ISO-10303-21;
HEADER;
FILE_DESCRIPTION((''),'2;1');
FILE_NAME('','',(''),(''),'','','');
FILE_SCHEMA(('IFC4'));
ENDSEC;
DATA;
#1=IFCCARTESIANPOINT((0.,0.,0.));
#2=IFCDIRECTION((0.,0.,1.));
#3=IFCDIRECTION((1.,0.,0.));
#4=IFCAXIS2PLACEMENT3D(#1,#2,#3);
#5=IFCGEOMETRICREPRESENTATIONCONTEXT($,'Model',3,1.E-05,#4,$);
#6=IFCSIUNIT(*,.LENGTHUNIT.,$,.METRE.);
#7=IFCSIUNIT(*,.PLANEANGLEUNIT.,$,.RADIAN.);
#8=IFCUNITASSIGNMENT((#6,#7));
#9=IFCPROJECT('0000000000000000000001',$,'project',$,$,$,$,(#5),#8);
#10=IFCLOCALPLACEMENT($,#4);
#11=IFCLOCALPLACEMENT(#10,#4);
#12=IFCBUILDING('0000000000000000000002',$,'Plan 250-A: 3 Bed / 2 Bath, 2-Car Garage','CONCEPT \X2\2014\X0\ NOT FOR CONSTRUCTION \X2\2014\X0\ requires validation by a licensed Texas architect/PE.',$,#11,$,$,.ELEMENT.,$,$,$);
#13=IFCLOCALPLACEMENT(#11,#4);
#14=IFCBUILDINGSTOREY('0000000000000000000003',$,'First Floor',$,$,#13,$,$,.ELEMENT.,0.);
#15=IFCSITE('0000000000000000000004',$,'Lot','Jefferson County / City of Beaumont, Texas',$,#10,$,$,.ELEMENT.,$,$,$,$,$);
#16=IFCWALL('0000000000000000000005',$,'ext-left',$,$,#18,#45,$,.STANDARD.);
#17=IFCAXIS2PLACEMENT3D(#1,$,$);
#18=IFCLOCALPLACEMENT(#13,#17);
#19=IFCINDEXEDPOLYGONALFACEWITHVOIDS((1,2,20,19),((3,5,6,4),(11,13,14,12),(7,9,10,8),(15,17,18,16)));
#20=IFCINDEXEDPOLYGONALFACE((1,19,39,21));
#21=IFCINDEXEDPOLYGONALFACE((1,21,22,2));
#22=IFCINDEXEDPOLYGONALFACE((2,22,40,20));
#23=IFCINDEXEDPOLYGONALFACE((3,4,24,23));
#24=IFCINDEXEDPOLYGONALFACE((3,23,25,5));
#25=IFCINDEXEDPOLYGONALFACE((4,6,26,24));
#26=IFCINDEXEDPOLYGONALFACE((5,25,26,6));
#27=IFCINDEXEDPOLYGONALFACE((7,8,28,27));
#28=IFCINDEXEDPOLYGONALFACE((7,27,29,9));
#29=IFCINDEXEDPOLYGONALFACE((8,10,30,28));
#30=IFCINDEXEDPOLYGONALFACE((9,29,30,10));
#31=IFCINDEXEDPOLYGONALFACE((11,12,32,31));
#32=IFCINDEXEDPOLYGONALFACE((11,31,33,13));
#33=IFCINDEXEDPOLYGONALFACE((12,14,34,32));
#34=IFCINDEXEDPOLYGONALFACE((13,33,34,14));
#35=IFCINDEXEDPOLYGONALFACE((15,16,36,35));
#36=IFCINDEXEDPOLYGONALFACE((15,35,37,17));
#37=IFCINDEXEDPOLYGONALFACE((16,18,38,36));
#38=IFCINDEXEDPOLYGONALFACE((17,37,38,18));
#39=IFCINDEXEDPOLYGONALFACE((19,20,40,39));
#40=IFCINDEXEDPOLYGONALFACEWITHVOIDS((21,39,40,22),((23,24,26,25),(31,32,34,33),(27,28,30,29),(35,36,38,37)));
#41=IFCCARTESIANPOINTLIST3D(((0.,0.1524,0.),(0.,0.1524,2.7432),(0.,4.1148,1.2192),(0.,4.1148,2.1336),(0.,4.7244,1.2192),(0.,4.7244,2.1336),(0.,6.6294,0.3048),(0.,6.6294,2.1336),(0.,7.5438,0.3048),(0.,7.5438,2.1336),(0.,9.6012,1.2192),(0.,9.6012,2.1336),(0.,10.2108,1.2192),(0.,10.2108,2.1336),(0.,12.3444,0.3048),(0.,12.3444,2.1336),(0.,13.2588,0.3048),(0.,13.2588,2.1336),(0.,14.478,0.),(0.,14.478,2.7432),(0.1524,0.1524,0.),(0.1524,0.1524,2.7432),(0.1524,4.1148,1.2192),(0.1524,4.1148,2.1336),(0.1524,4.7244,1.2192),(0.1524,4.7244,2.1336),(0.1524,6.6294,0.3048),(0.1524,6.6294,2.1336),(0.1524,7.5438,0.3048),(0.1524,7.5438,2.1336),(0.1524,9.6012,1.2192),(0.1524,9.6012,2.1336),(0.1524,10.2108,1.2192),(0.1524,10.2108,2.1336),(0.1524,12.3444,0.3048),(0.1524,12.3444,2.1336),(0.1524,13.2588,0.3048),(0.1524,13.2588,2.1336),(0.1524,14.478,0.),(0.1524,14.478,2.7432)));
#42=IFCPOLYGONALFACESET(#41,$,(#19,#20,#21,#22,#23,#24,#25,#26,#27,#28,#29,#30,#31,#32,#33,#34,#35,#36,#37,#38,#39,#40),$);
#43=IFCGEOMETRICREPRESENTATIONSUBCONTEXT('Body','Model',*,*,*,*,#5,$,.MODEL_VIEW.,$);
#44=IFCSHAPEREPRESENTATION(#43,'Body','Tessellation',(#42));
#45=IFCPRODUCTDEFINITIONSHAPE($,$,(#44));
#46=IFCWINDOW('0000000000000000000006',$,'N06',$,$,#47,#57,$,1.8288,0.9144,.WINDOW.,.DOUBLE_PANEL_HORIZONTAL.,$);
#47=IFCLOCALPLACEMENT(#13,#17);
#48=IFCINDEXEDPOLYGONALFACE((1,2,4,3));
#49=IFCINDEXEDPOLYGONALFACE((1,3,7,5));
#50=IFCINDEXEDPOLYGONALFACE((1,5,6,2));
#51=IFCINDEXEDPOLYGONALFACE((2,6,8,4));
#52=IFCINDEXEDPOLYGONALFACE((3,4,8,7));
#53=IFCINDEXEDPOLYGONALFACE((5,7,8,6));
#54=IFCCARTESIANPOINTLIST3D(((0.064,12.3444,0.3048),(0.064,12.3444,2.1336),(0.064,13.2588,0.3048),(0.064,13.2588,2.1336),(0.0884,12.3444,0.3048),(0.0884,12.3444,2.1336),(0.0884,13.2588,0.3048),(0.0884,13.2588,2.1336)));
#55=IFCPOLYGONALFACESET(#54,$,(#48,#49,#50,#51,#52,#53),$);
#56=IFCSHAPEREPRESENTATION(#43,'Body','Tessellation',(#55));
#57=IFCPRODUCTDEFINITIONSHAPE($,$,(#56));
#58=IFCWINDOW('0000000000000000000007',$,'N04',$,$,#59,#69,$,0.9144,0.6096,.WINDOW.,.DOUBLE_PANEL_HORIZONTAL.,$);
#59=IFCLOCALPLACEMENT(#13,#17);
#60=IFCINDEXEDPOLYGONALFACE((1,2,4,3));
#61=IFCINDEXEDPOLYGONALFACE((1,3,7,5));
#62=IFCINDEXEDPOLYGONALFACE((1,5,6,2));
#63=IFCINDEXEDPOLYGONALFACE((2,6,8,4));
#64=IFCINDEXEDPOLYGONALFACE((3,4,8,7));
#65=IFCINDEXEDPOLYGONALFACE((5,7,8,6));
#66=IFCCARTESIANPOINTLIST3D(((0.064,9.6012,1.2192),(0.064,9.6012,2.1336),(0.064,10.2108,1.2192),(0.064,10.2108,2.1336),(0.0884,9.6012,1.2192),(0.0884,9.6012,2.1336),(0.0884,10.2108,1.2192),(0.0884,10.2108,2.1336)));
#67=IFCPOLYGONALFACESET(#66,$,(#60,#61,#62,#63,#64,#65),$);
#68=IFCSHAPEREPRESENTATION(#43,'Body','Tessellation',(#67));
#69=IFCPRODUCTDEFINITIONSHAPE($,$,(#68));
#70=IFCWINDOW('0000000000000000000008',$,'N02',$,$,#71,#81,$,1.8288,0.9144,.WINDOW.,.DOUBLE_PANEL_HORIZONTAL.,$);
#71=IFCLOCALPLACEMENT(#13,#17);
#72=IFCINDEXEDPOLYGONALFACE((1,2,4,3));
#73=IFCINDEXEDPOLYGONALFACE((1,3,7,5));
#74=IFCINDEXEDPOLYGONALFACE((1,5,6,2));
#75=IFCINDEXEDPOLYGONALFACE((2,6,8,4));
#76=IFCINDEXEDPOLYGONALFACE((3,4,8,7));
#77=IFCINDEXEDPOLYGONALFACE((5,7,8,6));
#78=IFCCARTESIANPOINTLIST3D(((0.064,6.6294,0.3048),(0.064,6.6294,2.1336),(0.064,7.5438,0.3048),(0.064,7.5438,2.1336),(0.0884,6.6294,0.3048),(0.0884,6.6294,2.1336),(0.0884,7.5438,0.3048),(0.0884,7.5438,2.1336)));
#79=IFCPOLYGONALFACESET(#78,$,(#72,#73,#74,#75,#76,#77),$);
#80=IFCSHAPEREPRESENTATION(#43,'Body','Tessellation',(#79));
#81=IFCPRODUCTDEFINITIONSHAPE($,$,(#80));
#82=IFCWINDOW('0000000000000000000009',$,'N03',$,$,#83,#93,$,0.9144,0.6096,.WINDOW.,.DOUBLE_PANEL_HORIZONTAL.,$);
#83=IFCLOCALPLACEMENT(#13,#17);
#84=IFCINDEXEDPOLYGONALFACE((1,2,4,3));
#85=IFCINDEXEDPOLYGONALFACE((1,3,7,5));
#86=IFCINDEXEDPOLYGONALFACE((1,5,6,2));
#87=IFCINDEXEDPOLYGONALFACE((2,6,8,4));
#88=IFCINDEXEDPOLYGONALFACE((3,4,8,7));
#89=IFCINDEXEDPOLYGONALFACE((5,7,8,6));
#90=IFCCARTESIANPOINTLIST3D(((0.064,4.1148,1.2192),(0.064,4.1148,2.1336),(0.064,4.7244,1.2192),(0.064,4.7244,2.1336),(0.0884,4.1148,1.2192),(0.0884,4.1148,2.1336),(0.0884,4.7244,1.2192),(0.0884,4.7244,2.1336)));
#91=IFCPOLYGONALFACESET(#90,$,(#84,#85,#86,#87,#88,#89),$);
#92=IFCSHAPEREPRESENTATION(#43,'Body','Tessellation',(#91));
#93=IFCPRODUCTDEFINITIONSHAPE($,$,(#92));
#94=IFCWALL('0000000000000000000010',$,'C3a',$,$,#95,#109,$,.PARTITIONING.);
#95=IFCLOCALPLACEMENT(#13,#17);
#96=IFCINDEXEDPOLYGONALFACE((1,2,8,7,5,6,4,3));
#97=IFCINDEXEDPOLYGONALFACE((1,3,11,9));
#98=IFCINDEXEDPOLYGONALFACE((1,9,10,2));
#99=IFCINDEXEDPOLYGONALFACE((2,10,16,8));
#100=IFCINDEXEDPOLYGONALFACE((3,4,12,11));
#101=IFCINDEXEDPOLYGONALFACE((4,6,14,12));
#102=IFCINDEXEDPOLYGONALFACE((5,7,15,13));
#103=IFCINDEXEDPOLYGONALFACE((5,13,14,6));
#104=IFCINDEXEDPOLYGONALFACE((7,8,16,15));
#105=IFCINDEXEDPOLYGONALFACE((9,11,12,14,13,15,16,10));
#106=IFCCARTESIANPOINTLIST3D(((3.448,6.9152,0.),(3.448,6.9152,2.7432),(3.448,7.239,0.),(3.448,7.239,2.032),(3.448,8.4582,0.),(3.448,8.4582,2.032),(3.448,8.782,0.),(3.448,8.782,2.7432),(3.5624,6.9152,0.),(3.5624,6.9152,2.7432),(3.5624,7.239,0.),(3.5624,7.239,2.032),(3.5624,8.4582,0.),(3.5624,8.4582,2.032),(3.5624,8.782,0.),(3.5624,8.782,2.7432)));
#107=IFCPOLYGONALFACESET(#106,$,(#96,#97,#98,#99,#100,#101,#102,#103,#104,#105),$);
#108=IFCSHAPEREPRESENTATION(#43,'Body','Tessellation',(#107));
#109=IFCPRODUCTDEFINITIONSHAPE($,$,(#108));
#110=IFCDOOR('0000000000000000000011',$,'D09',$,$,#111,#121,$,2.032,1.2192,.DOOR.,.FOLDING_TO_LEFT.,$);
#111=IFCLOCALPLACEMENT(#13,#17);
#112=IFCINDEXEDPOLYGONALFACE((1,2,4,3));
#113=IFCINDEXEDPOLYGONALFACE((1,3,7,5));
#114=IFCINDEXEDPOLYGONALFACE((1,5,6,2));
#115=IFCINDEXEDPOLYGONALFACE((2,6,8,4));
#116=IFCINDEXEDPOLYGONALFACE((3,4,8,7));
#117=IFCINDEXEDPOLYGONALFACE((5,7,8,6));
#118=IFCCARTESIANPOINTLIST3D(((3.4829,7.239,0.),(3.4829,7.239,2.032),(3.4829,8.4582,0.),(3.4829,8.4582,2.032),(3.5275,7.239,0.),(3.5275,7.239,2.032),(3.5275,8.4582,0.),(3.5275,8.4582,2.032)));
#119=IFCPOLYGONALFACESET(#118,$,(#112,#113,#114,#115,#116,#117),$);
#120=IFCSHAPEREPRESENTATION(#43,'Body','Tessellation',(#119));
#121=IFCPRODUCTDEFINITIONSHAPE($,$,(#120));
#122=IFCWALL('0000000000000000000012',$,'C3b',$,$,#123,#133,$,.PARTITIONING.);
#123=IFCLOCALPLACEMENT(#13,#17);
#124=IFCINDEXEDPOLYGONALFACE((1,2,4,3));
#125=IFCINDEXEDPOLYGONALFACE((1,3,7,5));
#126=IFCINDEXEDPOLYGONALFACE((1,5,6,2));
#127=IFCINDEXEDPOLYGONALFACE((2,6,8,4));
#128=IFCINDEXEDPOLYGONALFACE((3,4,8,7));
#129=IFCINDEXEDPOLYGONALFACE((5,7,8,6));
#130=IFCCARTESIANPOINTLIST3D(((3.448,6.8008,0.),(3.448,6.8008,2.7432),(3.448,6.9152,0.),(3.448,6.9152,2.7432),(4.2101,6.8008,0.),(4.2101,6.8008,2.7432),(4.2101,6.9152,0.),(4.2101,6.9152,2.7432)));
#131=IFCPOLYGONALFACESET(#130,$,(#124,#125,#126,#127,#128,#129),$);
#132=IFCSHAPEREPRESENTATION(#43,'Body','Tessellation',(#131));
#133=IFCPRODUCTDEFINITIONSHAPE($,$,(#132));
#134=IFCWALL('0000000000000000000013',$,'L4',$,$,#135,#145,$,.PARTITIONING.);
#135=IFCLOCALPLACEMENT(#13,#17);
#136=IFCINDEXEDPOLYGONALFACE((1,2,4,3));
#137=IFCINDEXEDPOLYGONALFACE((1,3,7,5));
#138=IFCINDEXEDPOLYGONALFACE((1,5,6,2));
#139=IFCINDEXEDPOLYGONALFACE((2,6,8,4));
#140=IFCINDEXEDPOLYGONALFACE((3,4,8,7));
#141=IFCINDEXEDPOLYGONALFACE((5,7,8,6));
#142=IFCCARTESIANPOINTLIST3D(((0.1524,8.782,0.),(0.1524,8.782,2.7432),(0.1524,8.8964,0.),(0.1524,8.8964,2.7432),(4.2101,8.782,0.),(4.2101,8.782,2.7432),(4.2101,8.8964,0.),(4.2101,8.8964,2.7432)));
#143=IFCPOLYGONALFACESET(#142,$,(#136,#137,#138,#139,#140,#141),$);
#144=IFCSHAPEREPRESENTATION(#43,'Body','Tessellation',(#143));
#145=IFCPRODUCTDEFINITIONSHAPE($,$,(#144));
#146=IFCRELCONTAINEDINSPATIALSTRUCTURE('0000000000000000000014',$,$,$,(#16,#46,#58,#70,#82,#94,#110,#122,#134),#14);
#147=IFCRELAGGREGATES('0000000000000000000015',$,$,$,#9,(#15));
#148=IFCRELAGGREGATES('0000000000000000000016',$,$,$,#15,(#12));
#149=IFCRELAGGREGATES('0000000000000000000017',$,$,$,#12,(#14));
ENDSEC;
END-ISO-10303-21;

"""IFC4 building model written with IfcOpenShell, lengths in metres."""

from ifc_helpers import new_model, si_unit, frame, frame_2d, origin_with_axes, place, context, subcontext, project, spatial, rectangle, extrude, element, fill, save


model = new_model("IFC4")

# Units and contexts
model_context = context("Model", 3, precision=1e-05, world=origin_with_axes())
body_context = subcontext(model_context, "Body", "Model", "MODEL_VIEW")
ifc_project = project(units=[si_unit("LENGTHUNIT", "METRE"), si_unit("PLANEANGLEUNIT", "RADIAN")], contexts=[model_context])

# Site, building, storey
site_placement = place(None, origin_with_axes())
site = spatial("IfcSite", under=ifc_project, at=site_placement, Name="Lot", Description="Jefferson County / City of Beaumont, Texas", CompositionType="ELEMENT")
building_placement = place(site_placement, origin_with_axes())
building = spatial("IfcBuilding", under=site, at=building_placement, Name="Plan 250-A: 3 Bed / 2 Bath, 2-Car Garage", Description="CONCEPT — NOT FOR CONSTRUCTION — requires validation by a licensed Texas architect/PE.", CompositionType="ELEMENT")
storey_placement = place(building_placement, origin_with_axes())
storey = spatial("IfcBuildingStorey", under=building, at=storey_placement, Name="First Floor", CompositionType="ELEMENT", Elevation=0.0)

# Wall, openings, windows
wall_1_placement = place(storey_placement, frame((0.0762, 14.478, 0.0), z_axis=(0.0, 0.0, 1.0), x_axis=(0.0, -1.0, 0.0)))
wall_1 = element("IfcWall", 1, at=wall_1_placement, inside=storey, Name="ext-left", PredefinedType="STANDARD", context=body_context, shape_type="SweptSolid", body=[
    extrude(rectangle(XDim=14.3256, YDim=0.1524, at=frame_2d((7.1628, 0.0), x_axis=(1.0, 0.0))), origin_with_axes(), (0.0, 0.0, 1.0), 2.7432),
])
opening_1_placement = place(wall_1_placement, frame((1.2192, 0.0, 0.3048), z_axis=(0.0, 0.0, 1.0), x_axis=(1.0, 0.0, 0.0)))
opening_1 = element("IfcOpeningElement", 2, at=opening_1_placement, cuts=wall_1, PredefinedType="OPENING", context=body_context, shape_type="SweptSolid", body=[
    extrude(rectangle(XDim=0.9144, YDim=0.1829, at=frame_2d((0.4572, 0.0), x_axis=(1.0, 0.0))), origin_with_axes(), (0.0, 0.0, 1.0), 1.8288),
])
opening_2_placement = place(wall_1_placement, frame((4.2672, 0.0, 1.2192), z_axis=(0.0, 0.0, 1.0), x_axis=(1.0, 0.0, 0.0)))
opening_2 = element("IfcOpeningElement", 3, at=opening_2_placement, cuts=wall_1, PredefinedType="OPENING", context=body_context, shape_type="SweptSolid", body=[
    extrude(rectangle(XDim=0.6096, YDim=0.1829, at=frame_2d((0.3048, 0.0), x_axis=(1.0, 0.0))), origin_with_axes(), (0.0, 0.0, 1.0), 0.9144),
])
opening_3_placement = place(wall_1_placement, frame((6.9342, 0.0, 0.3048), z_axis=(0.0, 0.0, 1.0), x_axis=(1.0, 0.0, 0.0)))
opening_3 = element("IfcOpeningElement", 4, at=opening_3_placement, cuts=wall_1, PredefinedType="OPENING", context=body_context, shape_type="SweptSolid", body=[
    extrude(rectangle(XDim=0.9144, YDim=0.1829, at=frame_2d((0.4572, 0.0), x_axis=(1.0, 0.0))), origin_with_axes(), (0.0, 0.0, 1.0), 1.8288),
])
opening_4_placement = place(wall_1_placement, frame((9.7536, 0.0, 1.2192), z_axis=(0.0, 0.0, 1.0), x_axis=(1.0, 0.0, 0.0)))
opening_4 = element("IfcOpeningElement", 5, at=opening_4_placement, cuts=wall_1, PredefinedType="OPENING", context=body_context, shape_type="SweptSolid", body=[
    extrude(rectangle(XDim=0.6096, YDim=0.1829, at=frame_2d((0.3048, 0.0), x_axis=(1.0, 0.0))), origin_with_axes(), (0.0, 0.0, 1.0), 0.9144),
])
window_1_placement = place(opening_1_placement, origin_with_axes())
window_1 = element("IfcWindow", 6, at=window_1_placement, inside=storey, Name="N06", OverallHeight=1.8288, OverallWidth=0.9144, PartitioningType="DOUBLE_PANEL_HORIZONTAL", PredefinedType="WINDOW", context=body_context, shape_type="SweptSolid", body=[
    extrude(rectangle(XDim=0.9144, YDim=0.0244, at=frame_2d((0.4572, 0.0), x_axis=(1.0, 0.0))), origin_with_axes(), (0.0, 0.0, 1.0), 1.8288),
])
fill(opening_1, window_1)
window_2_placement = place(opening_2_placement, origin_with_axes())
window_2 = element("IfcWindow", 7, at=window_2_placement, inside=storey, Name="N04", OverallHeight=0.9144, OverallWidth=0.6096, PartitioningType="DOUBLE_PANEL_HORIZONTAL", PredefinedType="WINDOW", context=body_context, shape_type="SweptSolid", body=[
    extrude(rectangle(XDim=0.6096, YDim=0.0244, at=frame_2d((0.3048, 0.0), x_axis=(1.0, 0.0))), origin_with_axes(), (0.0, 0.0, 1.0), 0.9144),
])
fill(opening_2, window_2)
window_3_placement = place(opening_3_placement, origin_with_axes())
window_3 = element("IfcWindow", 8, at=window_3_placement, inside=storey, Name="N02", OverallHeight=1.8288, OverallWidth=0.9144, PartitioningType="DOUBLE_PANEL_HORIZONTAL", PredefinedType="WINDOW", context=body_context, shape_type="SweptSolid", body=[
    extrude(rectangle(XDim=0.9144, YDim=0.0244, at=frame_2d((0.4572, 0.0), x_axis=(1.0, 0.0))), origin_with_axes(), (0.0, 0.0, 1.0), 1.8288),
])
fill(opening_3, window_3)
window_4_placement = place(opening_4_placement, origin_with_axes())
window_4 = element("IfcWindow", 9, at=window_4_placement, inside=storey, Name="N03", OverallHeight=0.9144, OverallWidth=0.6096, PartitioningType="DOUBLE_PANEL_HORIZONTAL", PredefinedType="WINDOW", context=body_context, shape_type="SweptSolid", body=[
    extrude(rectangle(XDim=0.6096, YDim=0.0244, at=frame_2d((0.3048, 0.0), x_axis=(1.0, 0.0))), origin_with_axes(), (0.0, 0.0, 1.0), 0.9144),
])
fill(opening_4, window_4)

# Wall, opening, door
wall_2_placement = place(storey_placement, frame((3.5052, 6.9152, 0.0), z_axis=(0.0, 0.0, 1.0), x_axis=(0.0, 1.0, 0.0)))
wall_2 = element("IfcWall", 10, at=wall_2_placement, inside=storey, Name="C3a", PredefinedType="PARTITIONING", context=body_context, shape_type="SweptSolid", body=[
    extrude(rectangle(XDim=1.8669, YDim=0.1143, at=frame_2d((0.9335, 0.0), x_axis=(1.0, 0.0))), origin_with_axes(), (0.0, 0.0, 1.0), 2.7432),
])
opening_5_placement = place(wall_2_placement, frame((0.3239, 0.0, 0.0), z_axis=(0.0, 0.0, 1.0), x_axis=(1.0, 0.0, 0.0)))
opening_5 = element("IfcOpeningElement", 11, at=opening_5_placement, cuts=wall_2, PredefinedType="OPENING", context=body_context, shape_type="SweptSolid", body=[
    extrude(rectangle(XDim=1.2192, YDim=0.1448, at=frame_2d((0.6096, 0.0), x_axis=(1.0, 0.0))), origin_with_axes(), (0.0, 0.0, 1.0), 2.032),
])
door_1_placement = place(opening_5_placement, origin_with_axes())
door_1 = element("IfcDoor", 12, at=door_1_placement, inside=storey, Name="D09", OperationType="FOLDING_TO_LEFT", OverallHeight=2.032, OverallWidth=1.2192, PredefinedType="DOOR", context=body_context, shape_type="SweptSolid", body=[
    extrude(rectangle(XDim=1.2192, YDim=0.0445, at=frame_2d((0.6096, 0.0), x_axis=(1.0, 0.0))), origin_with_axes(), (0.0, 0.0, 1.0), 2.032),
])
fill(opening_5, door_1)

# Walls
wall_3_placement = place(storey_placement, frame((3.4481, 6.858, 0.0), z_axis=(0.0, 0.0, 1.0), x_axis=(1.0, 0.0, 0.0)))
element("IfcWall", 13, at=wall_3_placement, inside=storey, Name="C3b", PredefinedType="PARTITIONING", context=body_context, shape_type="SweptSolid", body=[
    extrude(rectangle(XDim=0.762, YDim=0.1143, at=frame_2d((0.381, 0.0), x_axis=(1.0, 0.0))), origin_with_axes(), (0.0, 0.0, 1.0), 2.7432),
])
wall_4_placement = place(storey_placement, frame((0.1524, 8.8392, 0.0), z_axis=(0.0, 0.0, 1.0), x_axis=(1.0, 0.0, 0.0)))
element("IfcWall", 14, at=wall_4_placement, inside=storey, Name="L4", PredefinedType="PARTITIONING", context=body_context, shape_type="SweptSolid", body=[
    extrude(rectangle(XDim=4.0577, YDim=0.1143, at=frame_2d((2.0288, 0.0), x_axis=(1.0, 0.0))), origin_with_axes(), (0.0, 0.0, 1.0), 2.7432),
])

save(model, "model.ifc")
